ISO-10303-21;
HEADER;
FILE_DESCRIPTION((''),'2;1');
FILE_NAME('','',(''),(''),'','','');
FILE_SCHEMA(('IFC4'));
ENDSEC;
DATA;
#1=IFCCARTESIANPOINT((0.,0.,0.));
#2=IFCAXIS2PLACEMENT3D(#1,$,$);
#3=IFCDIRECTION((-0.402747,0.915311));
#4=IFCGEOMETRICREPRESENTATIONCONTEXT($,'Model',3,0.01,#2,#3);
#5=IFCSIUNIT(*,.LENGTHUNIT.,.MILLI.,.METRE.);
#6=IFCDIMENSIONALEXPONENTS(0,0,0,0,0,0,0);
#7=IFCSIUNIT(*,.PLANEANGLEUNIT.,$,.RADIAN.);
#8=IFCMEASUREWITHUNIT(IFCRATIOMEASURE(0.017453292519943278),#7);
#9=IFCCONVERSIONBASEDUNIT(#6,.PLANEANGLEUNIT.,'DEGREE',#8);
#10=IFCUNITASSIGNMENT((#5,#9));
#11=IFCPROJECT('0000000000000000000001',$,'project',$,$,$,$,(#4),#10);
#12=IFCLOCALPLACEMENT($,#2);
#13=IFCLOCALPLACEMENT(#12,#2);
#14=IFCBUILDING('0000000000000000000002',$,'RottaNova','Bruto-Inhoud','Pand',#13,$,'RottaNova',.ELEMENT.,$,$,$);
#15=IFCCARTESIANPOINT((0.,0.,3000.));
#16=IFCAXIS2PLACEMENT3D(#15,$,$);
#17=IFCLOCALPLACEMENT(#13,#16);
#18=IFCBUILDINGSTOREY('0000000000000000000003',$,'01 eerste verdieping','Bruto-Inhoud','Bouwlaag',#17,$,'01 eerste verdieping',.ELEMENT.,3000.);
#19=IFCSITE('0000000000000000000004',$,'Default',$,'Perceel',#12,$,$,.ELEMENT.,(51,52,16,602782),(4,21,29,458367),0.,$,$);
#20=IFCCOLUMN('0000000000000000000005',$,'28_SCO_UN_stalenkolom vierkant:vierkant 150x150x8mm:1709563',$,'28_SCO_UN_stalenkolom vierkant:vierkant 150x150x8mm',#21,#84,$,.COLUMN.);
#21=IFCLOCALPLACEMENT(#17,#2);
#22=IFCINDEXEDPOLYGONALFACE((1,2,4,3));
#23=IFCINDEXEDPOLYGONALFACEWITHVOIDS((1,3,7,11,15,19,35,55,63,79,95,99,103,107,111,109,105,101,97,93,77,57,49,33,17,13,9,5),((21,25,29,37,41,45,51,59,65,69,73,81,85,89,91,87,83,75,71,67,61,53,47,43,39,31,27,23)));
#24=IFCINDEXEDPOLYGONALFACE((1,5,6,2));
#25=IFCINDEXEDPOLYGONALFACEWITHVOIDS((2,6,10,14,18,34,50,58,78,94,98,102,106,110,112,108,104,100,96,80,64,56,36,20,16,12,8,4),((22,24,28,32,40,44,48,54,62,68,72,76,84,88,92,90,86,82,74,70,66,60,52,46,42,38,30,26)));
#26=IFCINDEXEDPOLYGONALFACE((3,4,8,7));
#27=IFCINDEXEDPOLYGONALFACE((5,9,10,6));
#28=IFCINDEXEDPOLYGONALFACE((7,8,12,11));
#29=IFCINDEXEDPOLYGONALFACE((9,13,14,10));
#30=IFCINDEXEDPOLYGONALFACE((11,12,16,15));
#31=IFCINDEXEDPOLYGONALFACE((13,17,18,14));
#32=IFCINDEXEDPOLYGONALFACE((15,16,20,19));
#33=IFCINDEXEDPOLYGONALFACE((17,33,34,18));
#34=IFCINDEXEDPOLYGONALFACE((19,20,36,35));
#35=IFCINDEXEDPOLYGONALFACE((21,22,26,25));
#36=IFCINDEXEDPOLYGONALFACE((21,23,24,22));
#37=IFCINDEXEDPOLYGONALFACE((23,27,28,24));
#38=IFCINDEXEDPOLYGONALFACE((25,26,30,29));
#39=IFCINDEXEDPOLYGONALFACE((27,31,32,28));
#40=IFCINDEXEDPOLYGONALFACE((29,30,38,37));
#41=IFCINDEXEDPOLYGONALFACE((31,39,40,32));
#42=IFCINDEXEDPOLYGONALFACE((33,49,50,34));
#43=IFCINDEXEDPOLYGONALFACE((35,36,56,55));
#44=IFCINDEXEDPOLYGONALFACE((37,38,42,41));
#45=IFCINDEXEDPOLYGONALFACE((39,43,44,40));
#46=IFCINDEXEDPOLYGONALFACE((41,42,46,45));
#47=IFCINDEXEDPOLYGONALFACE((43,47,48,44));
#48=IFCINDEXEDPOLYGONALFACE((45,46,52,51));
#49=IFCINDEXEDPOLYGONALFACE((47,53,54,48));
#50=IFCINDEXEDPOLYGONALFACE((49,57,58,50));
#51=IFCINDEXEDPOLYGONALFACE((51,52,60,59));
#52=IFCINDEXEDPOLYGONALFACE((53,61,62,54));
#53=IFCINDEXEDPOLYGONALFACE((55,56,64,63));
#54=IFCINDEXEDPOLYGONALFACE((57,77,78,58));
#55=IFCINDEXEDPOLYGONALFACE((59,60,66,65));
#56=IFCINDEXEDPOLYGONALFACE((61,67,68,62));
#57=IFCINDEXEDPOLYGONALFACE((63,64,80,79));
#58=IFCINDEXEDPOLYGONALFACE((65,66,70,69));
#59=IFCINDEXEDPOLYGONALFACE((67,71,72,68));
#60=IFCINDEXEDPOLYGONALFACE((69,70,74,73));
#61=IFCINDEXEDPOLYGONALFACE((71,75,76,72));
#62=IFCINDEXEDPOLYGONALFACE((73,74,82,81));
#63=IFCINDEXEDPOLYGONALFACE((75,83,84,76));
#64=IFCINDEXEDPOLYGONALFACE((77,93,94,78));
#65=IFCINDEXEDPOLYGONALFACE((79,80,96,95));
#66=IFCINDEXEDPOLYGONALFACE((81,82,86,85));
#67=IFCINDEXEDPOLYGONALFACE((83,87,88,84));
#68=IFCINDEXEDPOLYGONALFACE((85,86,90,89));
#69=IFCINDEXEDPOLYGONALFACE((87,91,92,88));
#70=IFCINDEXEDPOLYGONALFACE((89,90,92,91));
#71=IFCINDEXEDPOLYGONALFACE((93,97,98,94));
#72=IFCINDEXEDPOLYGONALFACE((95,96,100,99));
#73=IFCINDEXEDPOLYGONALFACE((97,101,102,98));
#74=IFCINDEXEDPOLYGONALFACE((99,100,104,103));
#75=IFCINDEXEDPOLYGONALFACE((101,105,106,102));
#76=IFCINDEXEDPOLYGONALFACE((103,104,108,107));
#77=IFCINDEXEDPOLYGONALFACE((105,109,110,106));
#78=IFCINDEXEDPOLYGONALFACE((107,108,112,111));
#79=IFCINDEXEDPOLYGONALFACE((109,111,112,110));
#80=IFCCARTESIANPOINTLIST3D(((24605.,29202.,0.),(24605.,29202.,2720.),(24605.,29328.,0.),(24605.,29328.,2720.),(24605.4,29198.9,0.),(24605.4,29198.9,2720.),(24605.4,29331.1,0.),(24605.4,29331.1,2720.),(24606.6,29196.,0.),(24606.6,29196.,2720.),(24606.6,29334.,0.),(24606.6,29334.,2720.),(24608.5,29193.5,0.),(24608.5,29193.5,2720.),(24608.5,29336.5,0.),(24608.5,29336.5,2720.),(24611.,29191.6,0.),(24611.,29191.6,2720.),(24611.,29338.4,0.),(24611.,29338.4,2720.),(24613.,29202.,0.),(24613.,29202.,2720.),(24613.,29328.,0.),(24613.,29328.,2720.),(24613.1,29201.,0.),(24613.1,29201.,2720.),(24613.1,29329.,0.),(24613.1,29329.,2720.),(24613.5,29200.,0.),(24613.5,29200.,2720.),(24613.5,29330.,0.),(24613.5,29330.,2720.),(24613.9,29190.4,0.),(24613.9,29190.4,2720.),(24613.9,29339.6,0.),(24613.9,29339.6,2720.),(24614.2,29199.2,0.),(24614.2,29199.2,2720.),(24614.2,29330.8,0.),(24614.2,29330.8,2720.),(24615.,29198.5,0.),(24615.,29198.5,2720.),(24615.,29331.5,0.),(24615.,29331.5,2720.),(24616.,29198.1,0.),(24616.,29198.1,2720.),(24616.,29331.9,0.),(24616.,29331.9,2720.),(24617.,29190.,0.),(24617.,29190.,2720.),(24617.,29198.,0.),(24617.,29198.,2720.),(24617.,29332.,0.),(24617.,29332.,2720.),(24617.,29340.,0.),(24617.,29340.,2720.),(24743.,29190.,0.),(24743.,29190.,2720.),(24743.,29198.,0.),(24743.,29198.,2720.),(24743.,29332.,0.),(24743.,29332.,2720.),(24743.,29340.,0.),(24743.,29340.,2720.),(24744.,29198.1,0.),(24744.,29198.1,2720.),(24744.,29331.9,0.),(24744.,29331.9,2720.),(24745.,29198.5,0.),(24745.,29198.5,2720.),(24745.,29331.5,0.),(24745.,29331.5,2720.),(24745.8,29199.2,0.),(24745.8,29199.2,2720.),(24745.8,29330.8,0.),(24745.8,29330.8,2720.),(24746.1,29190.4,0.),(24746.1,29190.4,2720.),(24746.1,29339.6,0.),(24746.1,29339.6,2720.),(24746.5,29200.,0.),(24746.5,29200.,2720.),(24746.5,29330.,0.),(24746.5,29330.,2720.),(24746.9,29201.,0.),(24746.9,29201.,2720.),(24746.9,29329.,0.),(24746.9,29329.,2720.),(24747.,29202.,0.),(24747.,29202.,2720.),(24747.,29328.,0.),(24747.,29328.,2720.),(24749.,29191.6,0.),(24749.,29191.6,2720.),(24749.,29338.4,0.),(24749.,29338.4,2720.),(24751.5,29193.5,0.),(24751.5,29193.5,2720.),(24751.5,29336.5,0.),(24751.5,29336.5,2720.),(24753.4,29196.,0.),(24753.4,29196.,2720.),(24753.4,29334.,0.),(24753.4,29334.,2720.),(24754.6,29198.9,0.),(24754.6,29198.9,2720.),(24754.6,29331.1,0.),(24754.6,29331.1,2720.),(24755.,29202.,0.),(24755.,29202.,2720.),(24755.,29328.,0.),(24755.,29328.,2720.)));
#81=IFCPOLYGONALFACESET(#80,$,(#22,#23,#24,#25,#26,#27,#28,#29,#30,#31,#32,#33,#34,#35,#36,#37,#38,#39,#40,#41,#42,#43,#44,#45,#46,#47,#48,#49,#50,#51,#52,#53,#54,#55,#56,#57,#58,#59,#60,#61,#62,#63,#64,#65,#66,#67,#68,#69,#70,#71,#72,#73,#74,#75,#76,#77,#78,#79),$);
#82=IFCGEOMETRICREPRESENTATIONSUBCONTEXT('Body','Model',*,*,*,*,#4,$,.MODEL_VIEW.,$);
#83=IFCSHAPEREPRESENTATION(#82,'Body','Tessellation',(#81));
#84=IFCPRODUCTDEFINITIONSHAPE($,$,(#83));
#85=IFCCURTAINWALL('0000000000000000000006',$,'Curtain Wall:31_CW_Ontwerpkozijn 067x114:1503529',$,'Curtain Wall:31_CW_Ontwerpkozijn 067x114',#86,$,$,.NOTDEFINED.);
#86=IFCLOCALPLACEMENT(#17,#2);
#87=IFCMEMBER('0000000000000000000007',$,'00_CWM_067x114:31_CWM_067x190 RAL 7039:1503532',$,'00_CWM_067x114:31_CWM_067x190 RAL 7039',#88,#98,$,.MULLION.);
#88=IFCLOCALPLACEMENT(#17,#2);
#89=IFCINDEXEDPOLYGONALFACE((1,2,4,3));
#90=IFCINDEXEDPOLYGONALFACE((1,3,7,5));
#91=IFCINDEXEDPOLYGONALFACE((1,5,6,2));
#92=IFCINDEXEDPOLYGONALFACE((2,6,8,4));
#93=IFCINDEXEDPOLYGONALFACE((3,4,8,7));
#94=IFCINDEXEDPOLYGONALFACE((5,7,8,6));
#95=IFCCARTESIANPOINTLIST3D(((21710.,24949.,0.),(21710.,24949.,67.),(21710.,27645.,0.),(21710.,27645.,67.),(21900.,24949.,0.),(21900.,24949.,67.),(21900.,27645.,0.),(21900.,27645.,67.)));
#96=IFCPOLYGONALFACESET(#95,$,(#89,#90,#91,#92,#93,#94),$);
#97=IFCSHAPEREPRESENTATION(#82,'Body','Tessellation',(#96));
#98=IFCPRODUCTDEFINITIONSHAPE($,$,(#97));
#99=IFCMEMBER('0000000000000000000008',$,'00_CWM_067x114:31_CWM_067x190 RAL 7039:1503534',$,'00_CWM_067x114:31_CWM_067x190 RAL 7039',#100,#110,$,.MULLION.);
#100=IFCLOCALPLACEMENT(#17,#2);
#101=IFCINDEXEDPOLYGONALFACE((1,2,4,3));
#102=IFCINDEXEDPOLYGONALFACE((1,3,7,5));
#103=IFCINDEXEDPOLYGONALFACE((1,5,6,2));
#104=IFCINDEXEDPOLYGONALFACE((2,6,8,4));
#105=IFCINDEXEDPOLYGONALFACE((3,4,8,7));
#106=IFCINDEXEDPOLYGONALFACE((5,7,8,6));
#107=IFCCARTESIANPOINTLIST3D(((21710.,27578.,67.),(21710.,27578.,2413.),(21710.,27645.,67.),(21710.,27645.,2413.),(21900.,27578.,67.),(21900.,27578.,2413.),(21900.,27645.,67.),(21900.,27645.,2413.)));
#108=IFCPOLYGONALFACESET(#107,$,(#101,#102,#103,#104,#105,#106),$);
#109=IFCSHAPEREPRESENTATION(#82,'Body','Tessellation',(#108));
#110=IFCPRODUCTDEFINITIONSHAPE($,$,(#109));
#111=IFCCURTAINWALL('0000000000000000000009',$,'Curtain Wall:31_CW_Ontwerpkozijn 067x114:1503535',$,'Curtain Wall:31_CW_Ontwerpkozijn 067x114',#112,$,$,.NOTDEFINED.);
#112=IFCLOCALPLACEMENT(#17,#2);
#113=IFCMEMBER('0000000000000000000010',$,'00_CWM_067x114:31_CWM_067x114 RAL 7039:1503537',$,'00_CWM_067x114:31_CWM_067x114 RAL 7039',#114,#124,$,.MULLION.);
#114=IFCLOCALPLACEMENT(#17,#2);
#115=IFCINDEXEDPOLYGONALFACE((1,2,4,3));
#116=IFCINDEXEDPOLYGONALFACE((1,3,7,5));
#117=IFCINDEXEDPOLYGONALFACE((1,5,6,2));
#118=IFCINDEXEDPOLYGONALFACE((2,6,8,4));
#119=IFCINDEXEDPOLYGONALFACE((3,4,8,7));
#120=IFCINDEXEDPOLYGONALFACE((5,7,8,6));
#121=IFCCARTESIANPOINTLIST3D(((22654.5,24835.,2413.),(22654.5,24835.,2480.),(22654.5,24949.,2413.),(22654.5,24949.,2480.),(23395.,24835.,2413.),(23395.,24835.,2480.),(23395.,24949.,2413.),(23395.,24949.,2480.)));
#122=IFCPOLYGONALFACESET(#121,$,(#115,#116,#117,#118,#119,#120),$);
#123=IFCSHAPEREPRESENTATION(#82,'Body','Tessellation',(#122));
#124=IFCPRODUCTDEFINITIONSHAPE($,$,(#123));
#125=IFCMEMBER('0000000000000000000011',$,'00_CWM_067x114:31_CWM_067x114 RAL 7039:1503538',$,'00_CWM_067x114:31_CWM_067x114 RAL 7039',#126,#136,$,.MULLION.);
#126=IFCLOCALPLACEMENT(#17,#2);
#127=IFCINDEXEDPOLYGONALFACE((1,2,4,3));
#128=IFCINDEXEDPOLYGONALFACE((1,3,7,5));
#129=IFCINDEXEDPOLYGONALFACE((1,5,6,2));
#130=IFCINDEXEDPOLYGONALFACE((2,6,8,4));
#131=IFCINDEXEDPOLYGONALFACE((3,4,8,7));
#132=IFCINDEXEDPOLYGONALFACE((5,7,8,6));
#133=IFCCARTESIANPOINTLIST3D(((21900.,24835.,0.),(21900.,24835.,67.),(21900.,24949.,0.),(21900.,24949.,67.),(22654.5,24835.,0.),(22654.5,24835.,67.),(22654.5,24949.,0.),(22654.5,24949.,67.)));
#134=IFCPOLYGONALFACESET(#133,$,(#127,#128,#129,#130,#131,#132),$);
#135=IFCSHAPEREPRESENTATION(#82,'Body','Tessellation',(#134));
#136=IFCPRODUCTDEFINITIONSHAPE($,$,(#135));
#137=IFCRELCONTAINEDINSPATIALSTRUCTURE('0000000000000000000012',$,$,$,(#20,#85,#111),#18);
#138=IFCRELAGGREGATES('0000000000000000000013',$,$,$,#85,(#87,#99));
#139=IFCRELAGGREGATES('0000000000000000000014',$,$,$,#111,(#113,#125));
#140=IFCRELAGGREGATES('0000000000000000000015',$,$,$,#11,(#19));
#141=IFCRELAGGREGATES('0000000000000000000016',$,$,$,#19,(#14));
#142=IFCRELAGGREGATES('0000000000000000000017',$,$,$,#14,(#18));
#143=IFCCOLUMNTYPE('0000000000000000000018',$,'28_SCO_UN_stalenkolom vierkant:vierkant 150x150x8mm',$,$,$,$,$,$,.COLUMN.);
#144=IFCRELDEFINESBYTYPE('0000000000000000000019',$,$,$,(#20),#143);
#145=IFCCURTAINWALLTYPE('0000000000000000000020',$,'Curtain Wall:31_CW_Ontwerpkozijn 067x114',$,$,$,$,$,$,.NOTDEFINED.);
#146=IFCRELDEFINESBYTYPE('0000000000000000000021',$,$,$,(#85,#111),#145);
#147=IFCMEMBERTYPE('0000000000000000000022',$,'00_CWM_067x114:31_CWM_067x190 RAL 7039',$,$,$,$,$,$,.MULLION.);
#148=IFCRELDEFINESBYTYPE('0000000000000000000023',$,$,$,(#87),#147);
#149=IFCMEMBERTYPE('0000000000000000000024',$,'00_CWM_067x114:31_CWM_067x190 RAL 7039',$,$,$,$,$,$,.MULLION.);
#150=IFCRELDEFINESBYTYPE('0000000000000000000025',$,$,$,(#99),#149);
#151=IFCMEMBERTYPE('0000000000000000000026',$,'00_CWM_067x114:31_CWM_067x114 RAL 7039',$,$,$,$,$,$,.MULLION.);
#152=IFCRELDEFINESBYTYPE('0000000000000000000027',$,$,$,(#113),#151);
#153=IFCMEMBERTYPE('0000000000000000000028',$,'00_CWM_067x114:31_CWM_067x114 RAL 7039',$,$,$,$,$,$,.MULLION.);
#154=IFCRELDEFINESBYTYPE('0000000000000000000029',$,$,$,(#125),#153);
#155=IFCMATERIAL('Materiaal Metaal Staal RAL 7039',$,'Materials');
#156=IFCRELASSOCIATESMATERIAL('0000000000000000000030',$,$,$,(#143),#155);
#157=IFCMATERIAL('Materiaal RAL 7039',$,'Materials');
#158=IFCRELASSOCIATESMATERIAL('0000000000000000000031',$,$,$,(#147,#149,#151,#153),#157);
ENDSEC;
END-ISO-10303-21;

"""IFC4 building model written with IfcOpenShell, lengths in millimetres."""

from ifc_helpers import new_model, entity, si_unit, converted_unit, direction, frame, frame_2d, origin, origin_2d_with_axis, place, context, subcontext, project, spatial, polyline, circle_curve, parameter, trimmed, segment, composite_curve, rectangle, outline, extrude, source, transform, mapped, material, material_profile, profile_set, type_object, type_shapes, element, aggregate, save


model = new_model("IFC4")

# Units and contexts
model_context = context("Model", 3, precision=0.01, world=origin(), true_north=direction((-0.402747, 0.915311)))
body_context = subcontext(model_context, "Body", "Model", "MODEL_VIEW")
ifc_project = project(units=[si_unit("LENGTHUNIT", "METRE", prefix="MILLI"), converted_unit("PLANEANGLEUNIT", "DEGREE", entity("IfcRatioMeasure", 0.017453292519943278), si_unit("PLANEANGLEUNIT", "RADIAN"), dimensions=[0, 0, 0, 0, 0, 0, 0])], contexts=[model_context])

# Site, building, storey
site_placement = place(None, origin())
site = spatial("IfcSite", under=ifc_project, at=site_placement, Name="Default", ObjectType="Perceel", CompositionType="ELEMENT", RefLatitude=(51, 52, 16, 602782), RefLongitude=(4, 21, 29, 458367), RefElevation=0.0)
building_placement = place(site_placement, origin())
building = spatial("IfcBuilding", under=site, at=building_placement, Name="RottaNova", Description="Bruto-Inhoud", ObjectType="Pand", LongName="RottaNova", CompositionType="ELEMENT")
storey_placement = place(building_placement, frame((0.0, 0.0, 3000.0)))
storey = spatial("IfcBuildingStorey", under=building, at=storey_placement, Name="01 eerste verdieping", Description="Bruto-Inhoud", ObjectType="Bouwlaag", LongName="01 eerste verdieping", CompositionType="ELEMENT", Elevation=3000.0)

# Column
ifc_material_1 = material(Name="Materiaal Metaal Staal RAL 7039", Category="Materials")
ifc_material_profile_1 = material_profile(ifc_material_1, outline(composite_curve([segment(trimmed(circle_curve(frame_2d((63.0, -63.0), x_axis=(1.0, 0.0)), 12.0), [parameter(270.0)], [parameter(360.0)], True, "PARAMETER"), True, "CONTINUOUS"), segment(polyline([(75.0, -63.0), (75.0, 63.0)]), True, "CONTINUOUS"), segment(trimmed(circle_curve(frame_2d((63.0, 63.0), x_axis=(1.0, 0.0)), 12.0), [parameter(360.0)], [parameter(90.0)], True, "PARAMETER"), True, "CONTINUOUS"), segment(polyline([(63.0, 75.0), (-63.0, 75.0)]), True, "CONTINUOUS"), segment(trimmed(circle_curve(frame_2d((-63.0, 63.0), x_axis=(1.0, 0.0)), 12.0), [parameter(90.0)], [parameter(180.0)], True, "PARAMETER"), True, "CONTINUOUS"), segment(polyline([(-75.0, 63.0), (-75.0, -63.0)]), True, "CONTINUOUS"), segment(trimmed(circle_curve(frame_2d((-63.0, -63.0), x_axis=(1.0, 0.0)), 12.0), [parameter(180.0)], [parameter(270.0)], True, "PARAMETER"), True, "CONTINUOUS"), segment(polyline([(-63.0, -75.0), (63.0, -75.0)]), True, "CONTINUOUS")], self_intersect=False), holes=[composite_curve([segment(polyline([(-67.0, -63.0), (-67.0, 63.0)]), True, "CONTINUOUS"), segment(trimmed(circle_curve(frame_2d((-63.0, 63.0), x_axis=(1.0, 0.0)), 4.0), [parameter(90.0)], [parameter(180.0)], True, "PARAMETER"), False, "CONTINUOUS"), segment(polyline([(-63.0, 67.0), (63.0, 67.0)]), True, "CONTINUOUS"), segment(trimmed(circle_curve(frame_2d((63.0, 63.0), x_axis=(1.0, 0.0)), 4.0), [parameter(0.0)], [parameter(90.0)], True, "PARAMETER"), False, "CONTINUOUS"), segment(polyline([(67.0, 63.0), (67.0, -63.0)]), True, "CONTINUOUS"), segment(trimmed(circle_curve(frame_2d((63.0, -63.0), x_axis=(1.0, 0.0)), 4.0), [parameter(270.0)], [parameter(0.0)], True, "PARAMETER"), False, "CONTINUOUS"), segment(polyline([(63.0, -67.0), (-63.0, -67.0)]), True, "CONTINUOUS"), segment(trimmed(circle_curve(frame_2d((-63.0, -63.0), x_axis=(1.0, 0.0)), 4.0), [parameter(180.0)], [parameter(270.0)], True, "PARAMETER"), False, "CONTINUOUS")], self_intersect=False)]), Name="vierkant 150x150x8mm")
ifc_profile_set_1 = profile_set([ifc_material_profile_1], Name="vierkant 150x150x8mm")
column_type = type_object("IfcColumnType", Name="28_SCO_UN_stalenkolom vierkant:vierkant 150x150x8mm", PredefinedType="COLUMN", material=ifc_profile_set_1)
shared_shape_1 = source(origin(), body_context, "Body", "SweptSolid", [
    extrude(outline(composite_curve([segment(polyline([(-63.0, -75.0), (63.0, -75.0)]), True, "CONTINUOUS"), segment(trimmed(circle_curve(frame_2d((63.0, -63.0), x_axis=(-1.0, 0.0)), 12.0), [parameter(90.0)], [parameter(180.0)], True, "PARAMETER"), True, "CONTINUOUS"), segment(polyline([(75.0, -63.0), (75.0, 63.0)]), True, "CONTINUOUS"), segment(trimmed(circle_curve(frame_2d((63.0, 63.0), x_axis=(-1.0, 0.0)), 12.0), [parameter(180.0)], [parameter(270.0)], True, "PARAMETER"), True, "CONTINUOUS"), segment(polyline([(63.0, 75.0), (-63.0, 75.0)]), True, "CONTINUOUS"), segment(trimmed(circle_curve(frame_2d((-63.0, 63.0), x_axis=(-1.0, 0.0)), 12.0), [parameter(270.0)], [parameter(0.0)], True, "PARAMETER"), True, "CONTINUOUS"), segment(polyline([(-75.0, 63.0), (-75.0, -63.0)]), True, "CONTINUOUS"), segment(trimmed(circle_curve(frame_2d((-63.0, -63.0), x_axis=(-1.0, 0.0)), 12.0), [parameter(0.0)], [parameter(90.0)], True, "PARAMETER"), True, "CONTINUOUS")], self_intersect=False), holes=[composite_curve([segment(trimmed(circle_curve(frame_2d((63.0, -63.0), x_axis=(-1.0, 0.0)), 4.0), [parameter(90.0)], [parameter(180.0)], True, "PARAMETER"), False, "CONTINUOUS"), segment(polyline([(63.0, -67.0), (-63.0, -67.0)]), True, "CONTINUOUS"), segment(trimmed(circle_curve(frame_2d((-63.0, -63.0), x_axis=(-1.0, 0.0)), 4.0), [parameter(0.0)], [parameter(90.0)], True, "PARAMETER"), False, "CONTINUOUS"), segment(polyline([(-67.0, -63.0), (-67.0, 63.0)]), True, "CONTINUOUS"), segment(trimmed(circle_curve(frame_2d((-63.0, 63.0), x_axis=(-1.0, 0.0)), 4.0), [parameter(270.0)], [parameter(360.0)], True, "PARAMETER"), False, "CONTINUOUS"), segment(polyline([(-63.0, 67.0), (63.0, 67.0)]), True, "CONTINUOUS"), segment(trimmed(circle_curve(frame_2d((63.0, 63.0), x_axis=(-1.0, 0.0)), 4.0), [parameter(180.0)], [parameter(270.0)], True, "PARAMETER"), False, "CONTINUOUS"), segment(polyline([(67.0, 63.0), (67.0, -63.0)]), True, "CONTINUOUS")], self_intersect=False)]), frame((76.6, 76.6, 0.0), z_axis=(0.0, 0.0, 1.0), x_axis=(-1.0, 0.0, 0.0)), (0.0, 0.0, 1.0), 2720.0),
])
type_shapes(column_type, [shared_shape_1])
column_placement = place(storey_placement, frame((24603.4, 29188.4, 0.0)))
element("IfcColumn", 1, at=column_placement, inside=storey, type_object=column_type, Name="28_SCO_UN_stalenkolom vierkant:vierkant 150x150x8mm:1709563", ObjectType="28_SCO_UN_stalenkolom vierkant:vierkant 150x150x8mm", PredefinedType="COLUMN", context=body_context, shape_type="MappedRepresentation", body=[
    mapped(shared_shape_1, transform((0.0, 0.0, 0.0), scale=1.0)),
])

# Curtain wall, members
curtain_wall_type = type_object("IfcCurtainWallType", Name="Curtain Wall:31_CW_Ontwerpkozijn 067x114", PredefinedType="NOTDEFINED")
curtain_wall_1_placement = place(storey_placement, frame((0.0, 0.0, -3000.0)))
curtain_wall_1 = element("IfcCurtainWall", 2, at=curtain_wall_1_placement, inside=storey, type_object=curtain_wall_type, Name="Curtain Wall:31_CW_Ontwerpkozijn 067x114:1503529", ObjectType="Curtain Wall:31_CW_Ontwerpkozijn 067x114", PredefinedType="NOTDEFINED")
ifc_material_2 = material(Name="Materiaal RAL 7039", Category="Materials")
ifc_material_profile_2 = material_profile(ifc_material_2, rectangle(XDim=190.0, YDim=67.0, at=origin_2d_with_axis()), Name="31_CWM_067x190 RAL 7039")
ifc_profile_set_2 = profile_set([ifc_material_profile_2], Name="31_CWM_067x190 RAL 7039")
member_type_1 = type_object("IfcMemberType", Name="00_CWM_067x114:31_CWM_067x190 RAL 7039", PredefinedType="MULLION", material=ifc_profile_set_2)
shared_shape_2 = source(origin(), body_context, "Body", "SweptSolid", [
    extrude(rectangle(XDim=190.0, YDim=67.0, at=origin_2d_with_axis()), frame((-33.5, -95.0, -2696.0), z_axis=(0.0, 0.0, 1.0), x_axis=(0.0, -1.0, 0.0)), (0.0, 0.0, 1.0), 2696.0),
])
type_shapes(member_type_1, [shared_shape_2])
member_1_placement = place(curtain_wall_1_placement, frame((21710.0, 27645.0, 3000.0), z_axis=(0.0, 1.0, 0.0), x_axis=(0.0, 0.0, -1.0)))
member_1 = element("IfcMember", 3, at=member_1_placement, type_object=member_type_1, Name="00_CWM_067x114:31_CWM_067x190 RAL 7039:1503532", ObjectType="00_CWM_067x114:31_CWM_067x190 RAL 7039", PredefinedType="MULLION", context=body_context, shape_type="MappedRepresentation", body=[
    mapped(shared_shape_2, transform((0.0, 0.0, 0.0), scale=1.0)),
])
member_type_2 = type_object("IfcMemberType", Name="00_CWM_067x114:31_CWM_067x190 RAL 7039", PredefinedType="MULLION", material=ifc_profile_set_2)
shared_shape_3 = source(origin(), body_context, "Body", "SweptSolid", [
    extrude(rectangle(XDim=190.0, YDim=67.0, at=origin_2d_with_axis()), frame((-33.5, -95.0, -2346.0), z_axis=(0.0, 0.0, 1.0), x_axis=(0.0, -1.0, 0.0)), (0.0, 0.0, 1.0), 2346.0),
])
type_shapes(member_type_2, [shared_shape_3])
member_2_placement = place(curtain_wall_1_placement, frame((21710.0, 27645.0, 5413.0), z_axis=(0.0, 0.0, 1.0), x_axis=(0.0, 1.0, 0.0)))
member_2 = element("IfcMember", 4, at=member_2_placement, type_object=member_type_2, Name="00_CWM_067x114:31_CWM_067x190 RAL 7039:1503534", ObjectType="00_CWM_067x114:31_CWM_067x190 RAL 7039", PredefinedType="MULLION", context=body_context, shape_type="MappedRepresentation", body=[
    mapped(shared_shape_3, transform((0.0, 0.0, 0.0), scale=1.0)),
])
aggregate(curtain_wall_1, [member_1, member_2])

# Curtain wall, members
curtain_wall_2_placement = place(storey_placement, frame((0.0, 0.0, -3000.0)))
curtain_wall_2 = element("IfcCurtainWall", 5, at=curtain_wall_2_placement, inside=storey, type_object=curtain_wall_type, Name="Curtain Wall:31_CW_Ontwerpkozijn 067x114:1503535", ObjectType="Curtain Wall:31_CW_Ontwerpkozijn 067x114", PredefinedType="NOTDEFINED")
ifc_material_profile_3 = material_profile(ifc_material_2, rectangle(XDim=114.0, YDim=67.0, at=origin_2d_with_axis()), Name="31_CWM_067x114 RAL 7039")
ifc_profile_set_3 = profile_set([ifc_material_profile_3], Name="31_CWM_067x114 RAL 7039")
member_type_3 = type_object("IfcMemberType", Name="00_CWM_067x114:31_CWM_067x114 RAL 7039", PredefinedType="MULLION", material=ifc_profile_set_3)
shared_shape_4 = source(origin(), body_context, "Body", "SweptSolid", [
    extrude(rectangle(XDim=114.0, YDim=67.0, at=frame_2d((0.0, 0.0), x_axis=(1.0, 0.0))), frame((-33.5, -57.0, -740.5), z_axis=(0.0, 0.0, 1.0), x_axis=(0.0, -1.0, 0.0)), (0.0, 0.0, 1.0), 740.5),
])
type_shapes(member_type_3, [shared_shape_4])
member_3_placement = place(curtain_wall_2_placement, frame((23395.0, 24835.0, 5480.0), z_axis=(1.0, 0.0, 0.0), x_axis=(0.0, 0.0, 1.0)))
member_3 = element("IfcMember", 6, at=member_3_placement, type_object=member_type_3, Name="00_CWM_067x114:31_CWM_067x114 RAL 7039:1503537", ObjectType="00_CWM_067x114:31_CWM_067x114 RAL 7039", PredefinedType="MULLION", context=body_context, shape_type="MappedRepresentation", body=[
    mapped(shared_shape_4, transform((0.0, 0.0, 0.0), scale=1.0)),
])
member_type_4 = type_object("IfcMemberType", Name="00_CWM_067x114:31_CWM_067x114 RAL 7039", PredefinedType="MULLION", material=ifc_profile_set_3)
shared_shape_5 = source(origin(), body_context, "Body", "SweptSolid", [
    extrude(rectangle(XDim=114.0, YDim=67.0, at=frame_2d((0.0, 0.0), x_axis=(1.0, 0.0))), frame((-33.5, -57.0, -754.5), z_axis=(0.0, 0.0, 1.0), x_axis=(0.0, -1.0, 0.0)), (0.0, 0.0, 1.0), 754.5),
])
type_shapes(member_type_4, [shared_shape_5])
member_4_placement = place(curtain_wall_2_placement, frame((21900.0, 24835.0, 3000.0), z_axis=(-1.0, 0.0, 0.0), x_axis=(0.0, 0.0, -1.0)))
member_4 = element("IfcMember", 7, at=member_4_placement, type_object=member_type_4, Name="00_CWM_067x114:31_CWM_067x114 RAL 7039:1503538", ObjectType="00_CWM_067x114:31_CWM_067x114 RAL 7039", PredefinedType="MULLION", context=body_context, shape_type="MappedRepresentation", body=[
    mapped(shared_shape_5, transform((0.0, 0.0, 0.0), scale=1.0)),
])
aggregate(curtain_wall_2, [member_3, member_4])

save(model, "model.ifc")
